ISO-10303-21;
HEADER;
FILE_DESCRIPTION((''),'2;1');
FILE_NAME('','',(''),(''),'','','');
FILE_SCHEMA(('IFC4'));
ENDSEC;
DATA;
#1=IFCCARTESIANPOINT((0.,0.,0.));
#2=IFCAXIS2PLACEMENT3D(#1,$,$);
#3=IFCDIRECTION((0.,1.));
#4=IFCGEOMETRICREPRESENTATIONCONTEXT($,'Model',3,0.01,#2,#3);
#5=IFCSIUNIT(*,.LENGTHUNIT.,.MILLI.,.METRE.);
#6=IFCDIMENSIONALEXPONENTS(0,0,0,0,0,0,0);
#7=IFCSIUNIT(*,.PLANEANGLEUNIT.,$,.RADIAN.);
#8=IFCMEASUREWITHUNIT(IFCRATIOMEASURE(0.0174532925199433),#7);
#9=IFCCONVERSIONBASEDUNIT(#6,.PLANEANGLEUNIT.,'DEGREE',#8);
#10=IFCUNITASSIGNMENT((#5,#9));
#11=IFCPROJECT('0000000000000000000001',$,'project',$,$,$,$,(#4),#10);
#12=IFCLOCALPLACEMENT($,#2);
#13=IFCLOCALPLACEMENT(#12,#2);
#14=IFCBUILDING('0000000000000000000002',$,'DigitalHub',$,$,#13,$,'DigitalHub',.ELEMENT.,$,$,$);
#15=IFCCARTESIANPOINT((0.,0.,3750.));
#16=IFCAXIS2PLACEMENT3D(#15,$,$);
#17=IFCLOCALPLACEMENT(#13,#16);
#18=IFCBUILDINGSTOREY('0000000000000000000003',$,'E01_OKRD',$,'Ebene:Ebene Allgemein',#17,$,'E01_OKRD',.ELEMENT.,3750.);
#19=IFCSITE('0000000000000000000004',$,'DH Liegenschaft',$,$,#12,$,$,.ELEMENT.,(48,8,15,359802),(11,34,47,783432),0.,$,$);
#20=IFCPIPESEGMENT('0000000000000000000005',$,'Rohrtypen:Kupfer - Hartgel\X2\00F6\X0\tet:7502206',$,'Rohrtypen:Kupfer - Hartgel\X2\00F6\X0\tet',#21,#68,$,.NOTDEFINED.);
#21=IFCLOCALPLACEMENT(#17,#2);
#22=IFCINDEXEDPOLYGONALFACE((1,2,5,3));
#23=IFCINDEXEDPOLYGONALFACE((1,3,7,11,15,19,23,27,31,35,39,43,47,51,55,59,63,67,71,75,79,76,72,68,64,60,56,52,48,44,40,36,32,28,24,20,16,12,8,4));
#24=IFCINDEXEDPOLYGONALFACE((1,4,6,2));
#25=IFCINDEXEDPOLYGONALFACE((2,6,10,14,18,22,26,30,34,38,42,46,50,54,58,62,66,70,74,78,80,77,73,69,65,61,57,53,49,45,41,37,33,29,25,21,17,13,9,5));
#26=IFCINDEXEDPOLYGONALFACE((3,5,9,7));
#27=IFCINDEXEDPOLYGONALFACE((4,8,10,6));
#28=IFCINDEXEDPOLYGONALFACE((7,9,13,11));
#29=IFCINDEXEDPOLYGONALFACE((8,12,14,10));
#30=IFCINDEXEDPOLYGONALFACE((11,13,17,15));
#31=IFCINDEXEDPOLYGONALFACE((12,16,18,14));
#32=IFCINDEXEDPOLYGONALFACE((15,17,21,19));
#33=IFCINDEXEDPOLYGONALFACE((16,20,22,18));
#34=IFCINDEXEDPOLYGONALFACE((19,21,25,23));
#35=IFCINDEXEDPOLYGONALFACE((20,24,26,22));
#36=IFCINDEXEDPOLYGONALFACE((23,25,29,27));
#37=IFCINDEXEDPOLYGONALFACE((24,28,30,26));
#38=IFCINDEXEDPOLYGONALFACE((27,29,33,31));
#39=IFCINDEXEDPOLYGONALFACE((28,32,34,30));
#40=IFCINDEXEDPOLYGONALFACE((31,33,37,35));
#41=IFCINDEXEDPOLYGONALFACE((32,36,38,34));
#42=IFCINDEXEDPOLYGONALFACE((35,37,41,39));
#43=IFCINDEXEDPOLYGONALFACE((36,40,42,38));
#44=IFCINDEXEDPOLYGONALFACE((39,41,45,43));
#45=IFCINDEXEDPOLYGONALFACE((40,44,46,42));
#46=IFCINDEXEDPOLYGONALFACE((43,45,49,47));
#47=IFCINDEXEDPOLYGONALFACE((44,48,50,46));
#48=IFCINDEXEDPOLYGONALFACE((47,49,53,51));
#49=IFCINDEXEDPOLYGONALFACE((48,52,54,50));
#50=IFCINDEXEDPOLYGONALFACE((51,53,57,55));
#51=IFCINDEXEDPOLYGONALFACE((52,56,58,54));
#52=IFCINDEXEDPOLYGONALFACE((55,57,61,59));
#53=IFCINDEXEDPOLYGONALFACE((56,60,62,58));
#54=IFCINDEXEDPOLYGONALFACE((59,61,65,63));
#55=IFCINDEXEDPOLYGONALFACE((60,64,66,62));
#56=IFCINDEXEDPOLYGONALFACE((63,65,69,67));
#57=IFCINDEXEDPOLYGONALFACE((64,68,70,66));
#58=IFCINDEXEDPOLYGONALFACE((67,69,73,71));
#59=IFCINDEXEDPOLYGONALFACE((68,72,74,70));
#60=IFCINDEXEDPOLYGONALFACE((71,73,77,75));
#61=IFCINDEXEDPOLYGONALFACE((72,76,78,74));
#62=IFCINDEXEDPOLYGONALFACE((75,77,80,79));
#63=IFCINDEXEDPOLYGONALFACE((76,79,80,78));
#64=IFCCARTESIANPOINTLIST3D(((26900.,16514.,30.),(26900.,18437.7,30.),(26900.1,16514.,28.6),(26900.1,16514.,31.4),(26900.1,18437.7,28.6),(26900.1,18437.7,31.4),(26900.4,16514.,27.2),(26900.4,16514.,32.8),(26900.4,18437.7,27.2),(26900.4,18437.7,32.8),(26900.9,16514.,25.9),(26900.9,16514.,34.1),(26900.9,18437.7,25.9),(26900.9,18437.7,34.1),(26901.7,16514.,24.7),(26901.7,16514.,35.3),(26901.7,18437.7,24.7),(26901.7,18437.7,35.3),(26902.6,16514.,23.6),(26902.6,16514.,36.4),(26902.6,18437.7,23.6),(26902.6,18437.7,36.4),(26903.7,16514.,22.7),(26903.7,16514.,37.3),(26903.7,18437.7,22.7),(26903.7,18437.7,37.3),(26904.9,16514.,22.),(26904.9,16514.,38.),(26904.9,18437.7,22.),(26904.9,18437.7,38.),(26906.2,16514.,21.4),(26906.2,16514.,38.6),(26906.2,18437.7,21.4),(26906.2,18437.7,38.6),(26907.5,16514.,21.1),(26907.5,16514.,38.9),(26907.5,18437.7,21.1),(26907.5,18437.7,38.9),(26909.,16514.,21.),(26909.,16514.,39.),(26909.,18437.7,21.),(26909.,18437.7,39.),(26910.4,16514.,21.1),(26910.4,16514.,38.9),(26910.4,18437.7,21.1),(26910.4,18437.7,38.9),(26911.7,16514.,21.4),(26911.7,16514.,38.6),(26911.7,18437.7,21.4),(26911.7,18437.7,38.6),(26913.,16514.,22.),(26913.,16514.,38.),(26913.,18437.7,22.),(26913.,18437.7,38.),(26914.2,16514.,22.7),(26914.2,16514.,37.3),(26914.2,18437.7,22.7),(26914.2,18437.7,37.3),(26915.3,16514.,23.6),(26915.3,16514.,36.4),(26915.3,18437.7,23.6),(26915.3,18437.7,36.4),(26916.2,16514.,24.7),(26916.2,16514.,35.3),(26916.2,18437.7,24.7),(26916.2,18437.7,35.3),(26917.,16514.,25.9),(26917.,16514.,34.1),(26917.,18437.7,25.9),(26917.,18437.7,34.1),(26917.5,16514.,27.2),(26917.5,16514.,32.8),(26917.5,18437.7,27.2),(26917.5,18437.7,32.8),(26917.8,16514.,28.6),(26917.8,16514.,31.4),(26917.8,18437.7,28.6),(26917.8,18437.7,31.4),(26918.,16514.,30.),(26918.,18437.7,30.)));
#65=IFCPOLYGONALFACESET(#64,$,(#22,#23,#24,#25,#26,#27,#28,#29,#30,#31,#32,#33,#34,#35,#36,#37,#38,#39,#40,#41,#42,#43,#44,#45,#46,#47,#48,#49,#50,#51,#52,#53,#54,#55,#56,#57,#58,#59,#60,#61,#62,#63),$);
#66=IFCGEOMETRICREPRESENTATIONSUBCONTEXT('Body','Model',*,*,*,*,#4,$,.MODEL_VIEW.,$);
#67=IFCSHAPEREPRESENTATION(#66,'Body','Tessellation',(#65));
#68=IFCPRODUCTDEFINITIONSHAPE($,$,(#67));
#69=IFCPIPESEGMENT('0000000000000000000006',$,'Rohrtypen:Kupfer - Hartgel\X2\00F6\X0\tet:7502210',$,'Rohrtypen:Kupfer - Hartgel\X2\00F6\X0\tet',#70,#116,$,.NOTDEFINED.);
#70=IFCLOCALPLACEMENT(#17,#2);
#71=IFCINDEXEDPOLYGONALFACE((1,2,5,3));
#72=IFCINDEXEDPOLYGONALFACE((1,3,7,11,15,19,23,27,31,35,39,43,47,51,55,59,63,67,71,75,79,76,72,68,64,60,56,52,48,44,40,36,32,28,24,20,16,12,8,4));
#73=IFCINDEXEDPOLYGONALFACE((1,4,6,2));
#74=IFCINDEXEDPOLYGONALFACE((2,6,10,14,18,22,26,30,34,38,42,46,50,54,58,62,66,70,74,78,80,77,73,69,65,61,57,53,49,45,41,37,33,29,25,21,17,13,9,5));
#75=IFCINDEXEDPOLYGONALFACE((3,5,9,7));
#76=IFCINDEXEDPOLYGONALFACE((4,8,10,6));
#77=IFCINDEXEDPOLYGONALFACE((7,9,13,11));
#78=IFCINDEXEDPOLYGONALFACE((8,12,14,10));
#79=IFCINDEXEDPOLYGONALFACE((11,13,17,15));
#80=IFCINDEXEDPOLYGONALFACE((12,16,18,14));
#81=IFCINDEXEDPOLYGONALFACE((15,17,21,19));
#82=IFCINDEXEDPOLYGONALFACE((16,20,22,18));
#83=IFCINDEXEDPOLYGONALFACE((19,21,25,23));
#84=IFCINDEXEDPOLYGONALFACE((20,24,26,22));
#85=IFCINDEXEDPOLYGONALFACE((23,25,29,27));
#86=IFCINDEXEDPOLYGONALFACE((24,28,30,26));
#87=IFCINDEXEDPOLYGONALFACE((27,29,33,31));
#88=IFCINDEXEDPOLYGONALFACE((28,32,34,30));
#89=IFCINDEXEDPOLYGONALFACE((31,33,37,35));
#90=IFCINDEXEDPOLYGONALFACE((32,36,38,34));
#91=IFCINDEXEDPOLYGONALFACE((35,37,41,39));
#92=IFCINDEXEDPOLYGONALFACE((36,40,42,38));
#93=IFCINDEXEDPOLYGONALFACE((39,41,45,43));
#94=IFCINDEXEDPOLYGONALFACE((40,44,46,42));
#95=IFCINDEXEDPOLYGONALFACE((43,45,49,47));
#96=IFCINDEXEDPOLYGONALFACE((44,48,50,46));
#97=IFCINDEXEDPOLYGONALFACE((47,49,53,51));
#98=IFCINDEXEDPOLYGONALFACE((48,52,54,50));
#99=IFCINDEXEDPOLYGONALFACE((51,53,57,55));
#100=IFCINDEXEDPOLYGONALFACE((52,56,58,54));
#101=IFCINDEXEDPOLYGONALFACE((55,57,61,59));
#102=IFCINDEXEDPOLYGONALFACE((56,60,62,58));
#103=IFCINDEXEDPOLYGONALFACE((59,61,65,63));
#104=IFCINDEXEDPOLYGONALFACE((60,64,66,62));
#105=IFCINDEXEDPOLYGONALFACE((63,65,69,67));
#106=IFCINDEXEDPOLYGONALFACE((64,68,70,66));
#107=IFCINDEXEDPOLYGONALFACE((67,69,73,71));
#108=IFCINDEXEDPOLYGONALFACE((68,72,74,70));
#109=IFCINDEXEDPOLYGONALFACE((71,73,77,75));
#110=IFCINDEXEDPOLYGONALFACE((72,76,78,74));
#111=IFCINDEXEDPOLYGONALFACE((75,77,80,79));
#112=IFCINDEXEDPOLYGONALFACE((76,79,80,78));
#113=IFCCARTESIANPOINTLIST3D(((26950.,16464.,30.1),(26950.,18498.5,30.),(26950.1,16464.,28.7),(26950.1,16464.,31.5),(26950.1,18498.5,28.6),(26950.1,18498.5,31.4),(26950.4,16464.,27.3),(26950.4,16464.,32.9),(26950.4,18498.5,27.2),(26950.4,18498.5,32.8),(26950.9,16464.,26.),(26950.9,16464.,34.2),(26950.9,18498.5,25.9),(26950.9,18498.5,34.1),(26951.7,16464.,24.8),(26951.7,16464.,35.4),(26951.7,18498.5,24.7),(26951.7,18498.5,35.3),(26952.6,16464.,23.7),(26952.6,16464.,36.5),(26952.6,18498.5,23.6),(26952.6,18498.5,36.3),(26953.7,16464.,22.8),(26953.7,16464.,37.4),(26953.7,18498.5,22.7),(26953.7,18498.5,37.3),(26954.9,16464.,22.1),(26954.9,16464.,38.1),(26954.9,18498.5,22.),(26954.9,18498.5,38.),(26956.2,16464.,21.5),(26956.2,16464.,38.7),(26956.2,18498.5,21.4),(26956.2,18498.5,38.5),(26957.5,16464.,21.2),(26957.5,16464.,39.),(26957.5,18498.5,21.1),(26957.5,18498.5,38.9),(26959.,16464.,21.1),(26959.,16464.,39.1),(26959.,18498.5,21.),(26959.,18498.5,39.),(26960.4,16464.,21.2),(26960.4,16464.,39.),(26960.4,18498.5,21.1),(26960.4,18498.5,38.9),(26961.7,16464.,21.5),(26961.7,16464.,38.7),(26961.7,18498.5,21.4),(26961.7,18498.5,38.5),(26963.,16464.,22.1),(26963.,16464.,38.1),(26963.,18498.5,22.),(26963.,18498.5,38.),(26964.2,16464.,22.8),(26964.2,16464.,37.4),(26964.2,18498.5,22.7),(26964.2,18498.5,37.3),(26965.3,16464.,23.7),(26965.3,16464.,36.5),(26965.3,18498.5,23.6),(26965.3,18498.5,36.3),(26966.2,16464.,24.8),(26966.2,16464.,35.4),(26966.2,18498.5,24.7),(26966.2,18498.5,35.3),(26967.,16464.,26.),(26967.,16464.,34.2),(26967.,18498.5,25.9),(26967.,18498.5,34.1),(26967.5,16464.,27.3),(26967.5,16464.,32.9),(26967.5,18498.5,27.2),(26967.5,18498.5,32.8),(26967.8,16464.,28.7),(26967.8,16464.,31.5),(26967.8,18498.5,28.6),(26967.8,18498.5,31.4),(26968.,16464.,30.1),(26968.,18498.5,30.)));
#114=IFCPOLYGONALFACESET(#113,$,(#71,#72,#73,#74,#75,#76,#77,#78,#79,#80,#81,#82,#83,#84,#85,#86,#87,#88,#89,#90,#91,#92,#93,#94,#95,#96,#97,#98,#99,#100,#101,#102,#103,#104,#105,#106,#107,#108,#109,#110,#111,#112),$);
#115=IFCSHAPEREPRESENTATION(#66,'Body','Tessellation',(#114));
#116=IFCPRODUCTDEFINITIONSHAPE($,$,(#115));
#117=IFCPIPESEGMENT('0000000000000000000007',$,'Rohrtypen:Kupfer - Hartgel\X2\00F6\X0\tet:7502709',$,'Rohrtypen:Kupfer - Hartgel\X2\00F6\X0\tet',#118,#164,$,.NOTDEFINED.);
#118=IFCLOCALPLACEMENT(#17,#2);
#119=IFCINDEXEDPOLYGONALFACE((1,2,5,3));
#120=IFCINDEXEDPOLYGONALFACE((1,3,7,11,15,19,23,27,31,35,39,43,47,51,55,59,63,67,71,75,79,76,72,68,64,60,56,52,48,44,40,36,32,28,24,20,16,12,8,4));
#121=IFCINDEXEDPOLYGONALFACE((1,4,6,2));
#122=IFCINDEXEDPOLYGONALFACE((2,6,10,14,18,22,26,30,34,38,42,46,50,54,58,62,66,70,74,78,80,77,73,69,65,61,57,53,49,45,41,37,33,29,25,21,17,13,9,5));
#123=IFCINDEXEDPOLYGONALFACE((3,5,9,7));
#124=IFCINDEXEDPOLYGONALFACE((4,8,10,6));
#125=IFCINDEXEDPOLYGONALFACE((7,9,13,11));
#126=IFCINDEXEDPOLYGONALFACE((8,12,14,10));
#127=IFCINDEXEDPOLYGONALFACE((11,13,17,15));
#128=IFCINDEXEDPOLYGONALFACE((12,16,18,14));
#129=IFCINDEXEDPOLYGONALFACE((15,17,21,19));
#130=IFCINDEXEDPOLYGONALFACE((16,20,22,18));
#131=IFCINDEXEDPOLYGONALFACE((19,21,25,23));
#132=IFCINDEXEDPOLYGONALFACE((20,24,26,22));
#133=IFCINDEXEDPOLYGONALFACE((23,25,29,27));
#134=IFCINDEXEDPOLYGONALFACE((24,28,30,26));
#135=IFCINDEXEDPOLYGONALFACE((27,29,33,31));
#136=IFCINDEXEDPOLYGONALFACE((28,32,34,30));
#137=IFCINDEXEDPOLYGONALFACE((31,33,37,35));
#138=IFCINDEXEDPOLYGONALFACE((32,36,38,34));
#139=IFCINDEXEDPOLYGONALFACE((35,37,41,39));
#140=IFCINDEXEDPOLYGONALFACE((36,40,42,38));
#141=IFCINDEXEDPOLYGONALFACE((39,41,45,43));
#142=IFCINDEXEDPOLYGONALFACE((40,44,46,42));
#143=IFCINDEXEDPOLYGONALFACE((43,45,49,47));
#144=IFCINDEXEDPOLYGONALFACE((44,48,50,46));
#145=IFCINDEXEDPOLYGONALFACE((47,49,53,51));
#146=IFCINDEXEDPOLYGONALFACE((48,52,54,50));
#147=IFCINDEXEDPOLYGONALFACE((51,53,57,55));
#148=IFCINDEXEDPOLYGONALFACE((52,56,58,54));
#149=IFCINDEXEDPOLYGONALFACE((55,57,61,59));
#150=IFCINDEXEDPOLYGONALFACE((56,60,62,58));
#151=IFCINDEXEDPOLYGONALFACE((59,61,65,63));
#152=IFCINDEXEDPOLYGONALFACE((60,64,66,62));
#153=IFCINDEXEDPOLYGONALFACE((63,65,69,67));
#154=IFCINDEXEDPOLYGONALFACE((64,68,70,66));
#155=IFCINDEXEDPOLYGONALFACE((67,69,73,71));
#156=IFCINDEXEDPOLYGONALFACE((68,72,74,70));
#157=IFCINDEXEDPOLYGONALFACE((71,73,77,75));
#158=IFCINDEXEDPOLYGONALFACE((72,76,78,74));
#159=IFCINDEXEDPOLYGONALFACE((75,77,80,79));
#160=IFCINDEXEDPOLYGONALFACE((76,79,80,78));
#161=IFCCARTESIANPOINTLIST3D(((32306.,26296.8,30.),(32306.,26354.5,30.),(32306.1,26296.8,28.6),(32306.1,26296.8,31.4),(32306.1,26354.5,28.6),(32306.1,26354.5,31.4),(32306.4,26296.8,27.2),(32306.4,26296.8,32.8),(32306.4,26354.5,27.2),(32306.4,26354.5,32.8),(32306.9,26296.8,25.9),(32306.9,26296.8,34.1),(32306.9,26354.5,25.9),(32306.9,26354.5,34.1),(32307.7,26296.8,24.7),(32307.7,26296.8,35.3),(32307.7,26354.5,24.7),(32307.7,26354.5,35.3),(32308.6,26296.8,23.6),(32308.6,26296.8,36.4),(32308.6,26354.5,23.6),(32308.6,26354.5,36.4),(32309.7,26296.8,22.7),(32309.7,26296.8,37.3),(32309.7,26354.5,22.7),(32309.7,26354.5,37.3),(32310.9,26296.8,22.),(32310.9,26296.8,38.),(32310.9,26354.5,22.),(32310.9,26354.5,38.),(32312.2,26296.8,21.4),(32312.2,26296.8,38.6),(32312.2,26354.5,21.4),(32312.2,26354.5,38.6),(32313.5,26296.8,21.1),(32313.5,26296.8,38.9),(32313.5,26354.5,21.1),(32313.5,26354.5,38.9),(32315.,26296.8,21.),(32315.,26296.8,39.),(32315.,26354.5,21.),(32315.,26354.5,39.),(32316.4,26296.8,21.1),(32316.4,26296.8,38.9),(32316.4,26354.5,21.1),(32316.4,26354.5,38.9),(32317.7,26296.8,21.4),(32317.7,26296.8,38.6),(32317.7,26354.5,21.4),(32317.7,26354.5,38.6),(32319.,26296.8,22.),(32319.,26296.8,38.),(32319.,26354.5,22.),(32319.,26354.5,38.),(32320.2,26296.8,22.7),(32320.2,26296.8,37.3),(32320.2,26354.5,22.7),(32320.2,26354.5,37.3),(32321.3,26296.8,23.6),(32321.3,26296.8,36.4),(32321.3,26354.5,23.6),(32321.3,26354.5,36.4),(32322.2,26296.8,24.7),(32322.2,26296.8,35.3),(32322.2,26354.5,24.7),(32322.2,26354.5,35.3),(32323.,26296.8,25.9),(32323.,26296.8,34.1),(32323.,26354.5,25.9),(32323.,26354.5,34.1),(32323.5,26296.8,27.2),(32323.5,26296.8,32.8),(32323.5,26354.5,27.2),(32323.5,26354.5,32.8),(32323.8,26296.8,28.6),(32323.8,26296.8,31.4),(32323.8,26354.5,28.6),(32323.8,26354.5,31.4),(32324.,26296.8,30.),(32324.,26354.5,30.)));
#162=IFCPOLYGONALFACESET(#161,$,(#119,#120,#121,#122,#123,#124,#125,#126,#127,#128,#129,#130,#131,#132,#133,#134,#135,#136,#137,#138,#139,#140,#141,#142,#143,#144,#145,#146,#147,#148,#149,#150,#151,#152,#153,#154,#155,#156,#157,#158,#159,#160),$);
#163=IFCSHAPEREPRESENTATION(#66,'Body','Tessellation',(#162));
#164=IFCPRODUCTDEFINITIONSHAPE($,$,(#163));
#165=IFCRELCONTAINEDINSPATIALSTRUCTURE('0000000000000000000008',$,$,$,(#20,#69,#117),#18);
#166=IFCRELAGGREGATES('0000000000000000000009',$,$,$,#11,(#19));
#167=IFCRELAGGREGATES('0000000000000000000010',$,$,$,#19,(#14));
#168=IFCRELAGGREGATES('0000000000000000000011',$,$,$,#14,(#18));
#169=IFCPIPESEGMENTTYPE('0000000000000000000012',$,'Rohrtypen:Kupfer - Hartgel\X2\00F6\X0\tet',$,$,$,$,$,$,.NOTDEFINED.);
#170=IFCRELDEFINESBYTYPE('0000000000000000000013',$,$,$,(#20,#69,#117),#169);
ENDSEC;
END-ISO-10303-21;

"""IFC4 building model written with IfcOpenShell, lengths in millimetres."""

from ifc_helpers import new_model, entity, si_unit, converted_unit, direction, frame, origin, place, context, subcontext, project, spatial, indexed_curve, outline, extrude, type_object, element, save


model = new_model("IFC4")

# Units and contexts
model_context = context("Model", 3, precision=0.01, world=origin(), true_north=direction((0.0, 1.0)))
body_context = subcontext(model_context, "Body", "Model", "MODEL_VIEW")
ifc_project = project(units=[si_unit("LENGTHUNIT", "METRE", prefix="MILLI"), converted_unit("PLANEANGLEUNIT", "DEGREE", entity("IfcRatioMeasure", 0.0174532925199433), si_unit("PLANEANGLEUNIT", "RADIAN"), dimensions=[0, 0, 0, 0, 0, 0, 0])], contexts=[model_context])

# Site, building, storey
site_placement = place(None, origin())
site = spatial("IfcSite", under=ifc_project, at=site_placement, Name="DH Liegenschaft", CompositionType="ELEMENT", RefLatitude=(48, 8, 15, 359802), RefLongitude=(11, 34, 47, 783432), RefElevation=0.0)
building_placement = place(site_placement, origin())
building = spatial("IfcBuilding", under=site, at=building_placement, Name="DigitalHub", LongName="DigitalHub", CompositionType="ELEMENT")
storey_placement = place(building_placement, frame((0.0, 0.0, 3750.0)))
storey = spatial("IfcBuildingStorey", under=building, at=storey_placement, Name="E01_OKRD", ObjectType="Ebene:Ebene Allgemein", LongName="E01_OKRD", CompositionType="ELEMENT", Elevation=3750.0)

# Pipe segments
pipe_segment_type = type_object("IfcPipeSegmentType", Name="Rohrtypen:Kupfer - Hartgelötet", PredefinedType="NOTDEFINED")
pipe_segment_1_placement = place(storey_placement, frame((26898.4, 16514.0, 19.4)))
element("IfcPipeSegment", 1, at=pipe_segment_1_placement, inside=storey, type_object=pipe_segment_type, Name="Rohrtypen:Kupfer - Hartgelötet:7502206", ObjectType="Rohrtypen:Kupfer - Hartgelötet", PredefinedType="NOTDEFINED", context=body_context, shape_type="SweptSolid", body=[
    extrude(outline(indexed_curve([(9.0, 0.0), (8.9, 1.4), (8.6, 2.8), (8.0, 4.1), (7.3, 5.3), (6.4, 6.4), (5.3, 7.3), (4.1, 8.0), (2.8, 8.6), (1.4, 8.9), (0.0, 9.0), (-1.4, 8.9), (-2.8, 8.6), (-4.1, 8.0), (-5.3, 7.3), (-6.4, 6.4), (-7.3, 5.3), (-8.0, 4.1), (-8.6, 2.8), (-8.9, 1.4), (-9.0, 0.0), (-8.9, -1.4), (-8.6, -2.8), (-8.0, -4.1), (-7.3, -5.3), (-6.4, -6.4), (-5.3, -7.3), (-4.1, -8.0), (-2.8, -8.6), (-1.4, -8.9), (0.0, -9.0), (1.4, -8.9), (2.8, -8.6), (4.1, -8.0), (5.3, -7.3), (6.4, -6.4), (7.3, -5.3), (8.0, -4.1), (8.6, -2.8), (8.9, -1.4), (9.0, 0.0)], self_intersect=False)), frame((10.6, 0.0, 10.6), z_axis=(0.0, 1.0, 0.0), x_axis=(1.0, 0.0, 0.0)), (0.0, 0.0, 1.0), 1923.7),
])
pipe_segment_2_placement = place(storey_placement, frame((26948.4, 16464.0, 19.4)))
element("IfcPipeSegment", 2, at=pipe_segment_2_placement, inside=storey, type_object=pipe_segment_type, Name="Rohrtypen:Kupfer - Hartgelötet:7502210", ObjectType="Rohrtypen:Kupfer - Hartgelötet", PredefinedType="NOTDEFINED", context=body_context, shape_type="SweptSolid", body=[
    extrude(outline(indexed_curve([(9.0, 0.0), (8.9, 1.4), (8.6, 2.8), (8.0, 4.1), (7.3, 5.3), (6.4, 6.4), (5.3, 7.3), (4.1, 8.0), (2.8, 8.6), (1.4, 8.9), (0.0, 9.0), (-1.4, 8.9), (-2.8, 8.6), (-4.1, 8.0), (-5.3, 7.3), (-6.4, 6.4), (-7.3, 5.3), (-8.0, 4.1), (-8.6, 2.8), (-8.9, 1.4), (-9.0, 0.0), (-8.9, -1.4), (-8.6, -2.8), (-8.0, -4.1), (-7.3, -5.3), (-6.4, -6.4), (-5.3, -7.3), (-4.1, -8.0), (-2.8, -8.6), (-1.4, -8.9), (0.0, -9.0), (1.4, -8.9), (2.8, -8.6), (4.1, -8.0), (5.3, -7.3), (6.4, -6.4), (7.3, -5.3), (8.0, -4.1), (8.6, -2.8), (8.9, -1.4), (9.0, 0.0)], self_intersect=False)), frame((10.6, 2034.5, 10.6), z_axis=(0.0, -1.0, 0.000068), x_axis=(1.0, 0.0, 0.0)), (0.0, 0.0, 1.0), 2034.5),
])
pipe_segment_3_placement = place(storey_placement, frame((32304.4, 26296.8, 19.4)))
element("IfcPipeSegment", 3, at=pipe_segment_3_placement, inside=storey, type_object=pipe_segment_type, Name="Rohrtypen:Kupfer - Hartgelötet:7502709", ObjectType="Rohrtypen:Kupfer - Hartgelötet", PredefinedType="NOTDEFINED", context=body_context, shape_type="SweptSolid", body=[
    extrude(outline(indexed_curve([(9.0, 0.0), (8.9, 1.4), (8.6, 2.8), (8.0, 4.1), (7.3, 5.3), (6.4, 6.4), (5.3, 7.3), (4.1, 8.0), (2.8, 8.6), (1.4, 8.9), (0.0, 9.0), (-1.4, 8.9), (-2.8, 8.6), (-4.1, 8.0), (-5.3, 7.3), (-6.4, 6.4), (-7.3, 5.3), (-8.0, 4.1), (-8.6, 2.8), (-8.9, 1.4), (-9.0, 0.0), (-8.9, -1.4), (-8.6, -2.8), (-8.0, -4.1), (-7.3, -5.3), (-6.4, -6.4), (-5.3, -7.3), (-4.1, -8.0), (-2.8, -8.6), (-1.4, -8.9), (0.0, -9.0), (1.4, -8.9), (2.8, -8.6), (4.1, -8.0), (5.3, -7.3), (6.4, -6.4), (7.3, -5.3), (8.0, -4.1), (8.6, -2.8), (8.9, -1.4), (9.0, 0.0)], self_intersect=False)), frame((10.6, 0.0, 10.6), z_axis=(0.0, 1.0, 0.0), x_axis=(-1.0, 0.0, 0.0)), (0.0, 0.0, 1.0), 57.7),
])

save(model, "model.ifc")
